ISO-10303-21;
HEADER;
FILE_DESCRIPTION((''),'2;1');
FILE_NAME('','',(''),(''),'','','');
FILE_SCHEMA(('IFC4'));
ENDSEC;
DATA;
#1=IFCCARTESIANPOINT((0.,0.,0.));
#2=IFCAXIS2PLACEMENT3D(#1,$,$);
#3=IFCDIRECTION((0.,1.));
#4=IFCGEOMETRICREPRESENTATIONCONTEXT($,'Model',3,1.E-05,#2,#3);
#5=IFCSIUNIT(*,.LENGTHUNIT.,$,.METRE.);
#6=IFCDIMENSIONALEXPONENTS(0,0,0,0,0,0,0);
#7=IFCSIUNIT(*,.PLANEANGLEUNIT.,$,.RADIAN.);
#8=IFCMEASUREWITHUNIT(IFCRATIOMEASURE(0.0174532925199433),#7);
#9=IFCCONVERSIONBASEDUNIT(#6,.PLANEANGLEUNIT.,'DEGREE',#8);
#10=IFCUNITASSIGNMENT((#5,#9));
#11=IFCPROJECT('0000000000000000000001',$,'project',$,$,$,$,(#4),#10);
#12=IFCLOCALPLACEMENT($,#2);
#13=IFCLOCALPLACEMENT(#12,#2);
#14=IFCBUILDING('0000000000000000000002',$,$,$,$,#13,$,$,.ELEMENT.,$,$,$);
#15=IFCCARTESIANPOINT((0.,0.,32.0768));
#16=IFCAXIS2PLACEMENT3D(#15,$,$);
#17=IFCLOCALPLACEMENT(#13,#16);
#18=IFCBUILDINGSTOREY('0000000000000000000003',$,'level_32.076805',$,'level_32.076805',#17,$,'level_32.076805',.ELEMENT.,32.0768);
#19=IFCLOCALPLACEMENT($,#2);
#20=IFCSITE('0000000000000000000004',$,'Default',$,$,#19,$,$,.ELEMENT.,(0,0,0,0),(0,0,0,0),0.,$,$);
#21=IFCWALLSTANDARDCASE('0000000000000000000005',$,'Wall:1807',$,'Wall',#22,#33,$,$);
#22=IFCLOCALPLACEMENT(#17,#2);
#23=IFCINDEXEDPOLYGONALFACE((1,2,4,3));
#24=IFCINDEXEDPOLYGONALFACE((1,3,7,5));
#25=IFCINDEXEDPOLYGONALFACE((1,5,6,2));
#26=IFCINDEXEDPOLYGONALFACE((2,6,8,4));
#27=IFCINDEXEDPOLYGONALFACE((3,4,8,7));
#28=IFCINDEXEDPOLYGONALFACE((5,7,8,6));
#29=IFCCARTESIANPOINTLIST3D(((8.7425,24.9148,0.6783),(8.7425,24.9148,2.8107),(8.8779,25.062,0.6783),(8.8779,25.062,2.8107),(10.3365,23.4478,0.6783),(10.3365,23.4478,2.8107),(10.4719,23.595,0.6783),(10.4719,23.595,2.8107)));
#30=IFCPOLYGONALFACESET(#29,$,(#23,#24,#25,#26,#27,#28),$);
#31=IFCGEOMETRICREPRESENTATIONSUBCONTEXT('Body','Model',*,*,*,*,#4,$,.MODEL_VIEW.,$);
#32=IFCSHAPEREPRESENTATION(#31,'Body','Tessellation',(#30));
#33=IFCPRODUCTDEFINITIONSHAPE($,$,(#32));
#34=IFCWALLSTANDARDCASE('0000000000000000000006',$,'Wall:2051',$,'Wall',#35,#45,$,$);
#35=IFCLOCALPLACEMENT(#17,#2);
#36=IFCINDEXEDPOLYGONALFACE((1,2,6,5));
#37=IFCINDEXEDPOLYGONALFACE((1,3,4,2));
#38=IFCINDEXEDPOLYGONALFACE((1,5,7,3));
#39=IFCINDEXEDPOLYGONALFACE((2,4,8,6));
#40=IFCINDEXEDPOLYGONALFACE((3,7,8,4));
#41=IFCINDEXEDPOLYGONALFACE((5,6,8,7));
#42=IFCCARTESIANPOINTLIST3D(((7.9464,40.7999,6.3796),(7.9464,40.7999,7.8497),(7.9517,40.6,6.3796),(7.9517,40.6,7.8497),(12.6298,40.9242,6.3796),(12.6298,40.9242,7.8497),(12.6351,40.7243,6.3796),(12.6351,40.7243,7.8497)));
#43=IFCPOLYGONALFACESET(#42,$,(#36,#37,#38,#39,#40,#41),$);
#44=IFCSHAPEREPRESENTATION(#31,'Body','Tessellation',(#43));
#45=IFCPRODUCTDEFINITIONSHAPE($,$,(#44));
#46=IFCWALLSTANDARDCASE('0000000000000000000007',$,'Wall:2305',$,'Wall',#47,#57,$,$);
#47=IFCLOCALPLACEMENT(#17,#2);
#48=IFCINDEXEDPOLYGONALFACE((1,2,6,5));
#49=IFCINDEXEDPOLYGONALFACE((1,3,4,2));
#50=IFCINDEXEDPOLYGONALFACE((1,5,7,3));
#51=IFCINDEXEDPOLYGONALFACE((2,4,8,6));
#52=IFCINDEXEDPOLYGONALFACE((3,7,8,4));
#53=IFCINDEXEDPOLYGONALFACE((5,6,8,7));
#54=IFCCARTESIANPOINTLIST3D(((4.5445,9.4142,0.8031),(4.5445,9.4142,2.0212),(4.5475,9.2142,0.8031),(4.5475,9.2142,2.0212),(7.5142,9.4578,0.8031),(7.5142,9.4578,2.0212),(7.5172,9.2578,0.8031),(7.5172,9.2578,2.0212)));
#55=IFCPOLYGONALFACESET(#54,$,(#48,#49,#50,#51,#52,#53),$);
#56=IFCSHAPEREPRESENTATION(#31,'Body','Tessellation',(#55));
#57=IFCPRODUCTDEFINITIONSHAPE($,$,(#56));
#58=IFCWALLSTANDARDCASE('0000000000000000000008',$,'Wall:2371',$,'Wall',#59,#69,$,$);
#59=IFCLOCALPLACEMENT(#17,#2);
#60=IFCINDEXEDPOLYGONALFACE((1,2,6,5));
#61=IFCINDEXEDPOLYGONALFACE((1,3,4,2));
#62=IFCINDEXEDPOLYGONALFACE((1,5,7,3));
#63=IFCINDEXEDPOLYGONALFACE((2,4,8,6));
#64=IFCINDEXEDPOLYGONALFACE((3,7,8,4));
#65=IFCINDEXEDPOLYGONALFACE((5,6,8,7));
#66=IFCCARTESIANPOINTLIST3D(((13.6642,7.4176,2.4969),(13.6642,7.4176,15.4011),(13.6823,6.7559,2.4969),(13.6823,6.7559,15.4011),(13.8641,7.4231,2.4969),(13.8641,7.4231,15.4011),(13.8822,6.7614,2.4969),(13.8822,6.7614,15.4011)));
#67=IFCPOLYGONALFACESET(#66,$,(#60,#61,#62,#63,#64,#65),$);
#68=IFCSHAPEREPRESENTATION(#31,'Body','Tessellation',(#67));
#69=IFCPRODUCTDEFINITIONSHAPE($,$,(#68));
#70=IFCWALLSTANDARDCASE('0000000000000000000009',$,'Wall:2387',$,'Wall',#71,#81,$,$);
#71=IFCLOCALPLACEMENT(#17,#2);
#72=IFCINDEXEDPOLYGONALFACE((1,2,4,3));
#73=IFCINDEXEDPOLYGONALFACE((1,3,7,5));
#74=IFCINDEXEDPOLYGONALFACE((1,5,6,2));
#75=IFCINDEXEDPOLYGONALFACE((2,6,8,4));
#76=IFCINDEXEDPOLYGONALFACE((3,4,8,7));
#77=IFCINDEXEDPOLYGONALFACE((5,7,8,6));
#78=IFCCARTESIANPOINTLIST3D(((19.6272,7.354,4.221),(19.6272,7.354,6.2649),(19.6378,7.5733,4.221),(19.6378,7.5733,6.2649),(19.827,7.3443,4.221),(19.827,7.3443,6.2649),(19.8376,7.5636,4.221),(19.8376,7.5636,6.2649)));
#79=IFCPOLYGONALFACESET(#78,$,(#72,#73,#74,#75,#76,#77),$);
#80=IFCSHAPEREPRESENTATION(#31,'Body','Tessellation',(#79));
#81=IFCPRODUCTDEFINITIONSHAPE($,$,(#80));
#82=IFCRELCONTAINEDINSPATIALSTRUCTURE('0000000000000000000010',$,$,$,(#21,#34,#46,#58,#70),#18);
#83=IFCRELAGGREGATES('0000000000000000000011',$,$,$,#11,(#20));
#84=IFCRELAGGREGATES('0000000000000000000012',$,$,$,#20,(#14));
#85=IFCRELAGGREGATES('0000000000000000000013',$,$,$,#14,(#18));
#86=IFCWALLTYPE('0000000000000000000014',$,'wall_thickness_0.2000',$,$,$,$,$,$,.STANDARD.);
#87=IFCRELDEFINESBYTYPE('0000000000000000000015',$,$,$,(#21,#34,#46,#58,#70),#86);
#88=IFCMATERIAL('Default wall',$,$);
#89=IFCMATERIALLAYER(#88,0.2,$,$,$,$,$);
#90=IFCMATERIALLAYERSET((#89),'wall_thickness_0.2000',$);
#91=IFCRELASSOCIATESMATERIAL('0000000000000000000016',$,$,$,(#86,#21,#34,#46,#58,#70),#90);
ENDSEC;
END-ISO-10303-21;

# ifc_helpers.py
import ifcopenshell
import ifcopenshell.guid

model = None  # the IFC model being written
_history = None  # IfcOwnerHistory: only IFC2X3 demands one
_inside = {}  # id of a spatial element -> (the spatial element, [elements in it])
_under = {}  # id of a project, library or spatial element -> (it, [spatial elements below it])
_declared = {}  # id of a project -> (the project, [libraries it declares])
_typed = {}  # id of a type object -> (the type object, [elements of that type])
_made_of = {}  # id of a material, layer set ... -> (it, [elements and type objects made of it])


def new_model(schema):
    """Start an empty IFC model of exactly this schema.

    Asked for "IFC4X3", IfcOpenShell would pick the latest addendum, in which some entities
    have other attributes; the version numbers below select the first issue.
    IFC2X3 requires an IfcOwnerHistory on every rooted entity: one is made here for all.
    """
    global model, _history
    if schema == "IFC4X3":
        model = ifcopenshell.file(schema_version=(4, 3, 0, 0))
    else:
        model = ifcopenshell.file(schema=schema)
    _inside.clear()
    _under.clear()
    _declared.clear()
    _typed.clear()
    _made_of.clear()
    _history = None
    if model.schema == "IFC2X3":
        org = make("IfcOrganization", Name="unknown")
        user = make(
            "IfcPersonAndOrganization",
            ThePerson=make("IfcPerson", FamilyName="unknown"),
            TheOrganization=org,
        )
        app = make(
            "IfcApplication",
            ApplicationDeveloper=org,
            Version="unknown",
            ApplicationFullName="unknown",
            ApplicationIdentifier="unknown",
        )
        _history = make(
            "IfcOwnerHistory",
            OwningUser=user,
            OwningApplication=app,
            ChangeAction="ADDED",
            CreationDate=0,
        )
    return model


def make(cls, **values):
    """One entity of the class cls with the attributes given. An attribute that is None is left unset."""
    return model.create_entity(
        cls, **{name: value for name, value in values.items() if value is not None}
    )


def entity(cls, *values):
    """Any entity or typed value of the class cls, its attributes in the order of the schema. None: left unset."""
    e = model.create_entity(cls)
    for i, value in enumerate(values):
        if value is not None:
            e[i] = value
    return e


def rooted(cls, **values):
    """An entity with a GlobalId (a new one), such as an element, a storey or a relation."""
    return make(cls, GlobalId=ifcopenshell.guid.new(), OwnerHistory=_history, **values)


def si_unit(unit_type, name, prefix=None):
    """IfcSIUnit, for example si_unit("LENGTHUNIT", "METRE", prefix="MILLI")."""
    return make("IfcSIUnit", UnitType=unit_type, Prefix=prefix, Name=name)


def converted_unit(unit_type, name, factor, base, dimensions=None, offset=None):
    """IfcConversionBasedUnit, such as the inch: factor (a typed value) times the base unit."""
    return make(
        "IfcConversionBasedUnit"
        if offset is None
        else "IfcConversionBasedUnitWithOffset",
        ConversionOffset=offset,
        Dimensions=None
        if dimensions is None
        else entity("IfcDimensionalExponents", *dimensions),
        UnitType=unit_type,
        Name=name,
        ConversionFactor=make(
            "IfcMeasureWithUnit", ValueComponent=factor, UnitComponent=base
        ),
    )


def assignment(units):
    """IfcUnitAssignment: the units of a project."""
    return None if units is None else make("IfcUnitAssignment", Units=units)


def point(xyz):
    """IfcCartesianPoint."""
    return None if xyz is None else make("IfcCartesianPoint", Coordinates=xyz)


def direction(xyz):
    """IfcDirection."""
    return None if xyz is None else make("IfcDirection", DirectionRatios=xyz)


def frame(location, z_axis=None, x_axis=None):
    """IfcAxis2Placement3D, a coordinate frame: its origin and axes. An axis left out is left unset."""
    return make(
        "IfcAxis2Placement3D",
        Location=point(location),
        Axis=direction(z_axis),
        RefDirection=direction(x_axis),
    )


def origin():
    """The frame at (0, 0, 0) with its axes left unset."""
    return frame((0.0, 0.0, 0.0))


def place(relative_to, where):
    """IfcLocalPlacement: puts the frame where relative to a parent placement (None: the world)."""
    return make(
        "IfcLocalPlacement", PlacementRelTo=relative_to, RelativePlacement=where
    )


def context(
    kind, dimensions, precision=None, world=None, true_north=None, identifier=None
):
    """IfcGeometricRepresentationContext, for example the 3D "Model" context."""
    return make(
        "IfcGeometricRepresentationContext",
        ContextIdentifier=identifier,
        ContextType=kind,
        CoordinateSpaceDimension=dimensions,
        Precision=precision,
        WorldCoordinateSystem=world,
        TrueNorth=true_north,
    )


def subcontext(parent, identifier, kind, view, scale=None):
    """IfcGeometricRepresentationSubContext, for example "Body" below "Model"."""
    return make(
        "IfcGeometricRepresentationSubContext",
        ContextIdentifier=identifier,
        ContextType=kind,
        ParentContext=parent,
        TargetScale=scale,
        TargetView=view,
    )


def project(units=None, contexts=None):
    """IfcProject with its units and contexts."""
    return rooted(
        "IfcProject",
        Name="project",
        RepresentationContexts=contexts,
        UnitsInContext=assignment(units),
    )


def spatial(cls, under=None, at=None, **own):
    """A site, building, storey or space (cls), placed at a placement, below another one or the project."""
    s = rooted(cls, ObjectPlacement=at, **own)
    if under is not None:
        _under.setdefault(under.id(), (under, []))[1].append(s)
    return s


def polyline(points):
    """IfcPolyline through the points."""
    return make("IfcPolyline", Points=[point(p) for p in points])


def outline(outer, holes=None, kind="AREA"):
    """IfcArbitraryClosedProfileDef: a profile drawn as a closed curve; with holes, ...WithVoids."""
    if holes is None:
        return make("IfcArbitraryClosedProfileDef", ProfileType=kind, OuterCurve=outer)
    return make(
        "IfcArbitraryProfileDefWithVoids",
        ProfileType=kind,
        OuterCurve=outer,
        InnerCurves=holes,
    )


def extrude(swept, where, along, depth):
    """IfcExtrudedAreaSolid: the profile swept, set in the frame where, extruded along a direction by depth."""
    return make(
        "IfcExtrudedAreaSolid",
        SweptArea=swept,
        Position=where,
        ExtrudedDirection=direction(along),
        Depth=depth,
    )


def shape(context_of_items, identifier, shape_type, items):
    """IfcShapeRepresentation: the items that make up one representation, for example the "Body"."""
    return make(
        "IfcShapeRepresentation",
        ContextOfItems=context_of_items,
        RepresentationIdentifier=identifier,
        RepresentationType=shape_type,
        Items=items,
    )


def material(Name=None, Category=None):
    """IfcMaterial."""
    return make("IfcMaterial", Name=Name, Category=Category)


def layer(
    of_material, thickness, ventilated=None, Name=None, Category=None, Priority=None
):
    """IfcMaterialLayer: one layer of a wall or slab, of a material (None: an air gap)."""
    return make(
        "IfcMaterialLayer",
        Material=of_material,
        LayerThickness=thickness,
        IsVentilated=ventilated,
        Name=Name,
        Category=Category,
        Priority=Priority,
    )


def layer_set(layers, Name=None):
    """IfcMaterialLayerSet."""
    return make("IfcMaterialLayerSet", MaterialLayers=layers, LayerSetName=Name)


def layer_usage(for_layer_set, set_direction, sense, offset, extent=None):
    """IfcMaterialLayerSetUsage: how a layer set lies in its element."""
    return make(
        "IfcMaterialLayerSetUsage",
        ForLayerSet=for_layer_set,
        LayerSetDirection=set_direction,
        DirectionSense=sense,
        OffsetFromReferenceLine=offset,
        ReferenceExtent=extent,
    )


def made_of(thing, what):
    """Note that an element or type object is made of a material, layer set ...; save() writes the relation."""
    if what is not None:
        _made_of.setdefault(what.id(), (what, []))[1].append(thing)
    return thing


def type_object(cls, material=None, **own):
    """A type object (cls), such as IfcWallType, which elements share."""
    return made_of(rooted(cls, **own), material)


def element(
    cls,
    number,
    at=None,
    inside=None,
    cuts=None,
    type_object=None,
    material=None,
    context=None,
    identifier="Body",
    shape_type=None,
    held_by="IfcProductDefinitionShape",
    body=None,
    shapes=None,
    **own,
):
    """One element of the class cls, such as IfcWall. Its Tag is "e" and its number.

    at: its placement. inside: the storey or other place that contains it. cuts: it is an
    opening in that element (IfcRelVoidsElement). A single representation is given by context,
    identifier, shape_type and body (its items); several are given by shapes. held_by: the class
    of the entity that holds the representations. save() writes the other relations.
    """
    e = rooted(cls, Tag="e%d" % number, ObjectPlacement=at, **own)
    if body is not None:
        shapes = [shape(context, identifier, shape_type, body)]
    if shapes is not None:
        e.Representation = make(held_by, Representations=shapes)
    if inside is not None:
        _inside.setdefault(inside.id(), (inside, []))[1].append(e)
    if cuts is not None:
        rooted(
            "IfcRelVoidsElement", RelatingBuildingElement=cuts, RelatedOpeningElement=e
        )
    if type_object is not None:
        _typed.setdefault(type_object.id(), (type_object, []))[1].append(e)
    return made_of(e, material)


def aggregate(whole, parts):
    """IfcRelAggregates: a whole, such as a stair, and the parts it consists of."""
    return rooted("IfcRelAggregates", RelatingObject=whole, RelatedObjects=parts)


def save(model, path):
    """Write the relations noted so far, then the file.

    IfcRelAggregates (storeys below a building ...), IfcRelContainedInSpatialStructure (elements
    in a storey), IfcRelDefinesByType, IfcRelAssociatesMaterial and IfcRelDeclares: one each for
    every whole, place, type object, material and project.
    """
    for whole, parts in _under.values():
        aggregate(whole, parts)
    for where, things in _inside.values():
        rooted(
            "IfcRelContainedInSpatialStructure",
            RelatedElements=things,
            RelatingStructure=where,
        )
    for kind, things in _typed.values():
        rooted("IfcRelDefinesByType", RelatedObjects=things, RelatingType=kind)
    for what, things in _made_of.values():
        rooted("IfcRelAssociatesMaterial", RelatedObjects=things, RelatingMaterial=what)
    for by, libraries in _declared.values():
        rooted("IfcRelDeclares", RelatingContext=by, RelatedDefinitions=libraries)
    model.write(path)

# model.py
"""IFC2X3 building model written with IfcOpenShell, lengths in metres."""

from ifc_helpers import new_model, entity, si_unit, converted_unit, direction, frame, origin, place, context, subcontext, project, spatial, polyline, outline, extrude, material, layer, layer_set, layer_usage, type_object, element, save


model = new_model("IFC2X3")

# Units and contexts
model_context = context("Model", 3, precision=1e-05, world=origin(), true_north=direction((0.0, 1.0)))
body_context = subcontext(model_context, "Body", "Model", "MODEL_VIEW")
ifc_project = project(units=[si_unit("LENGTHUNIT", "METRE"), converted_unit("PLANEANGLEUNIT", "DEGREE", entity("IfcRatioMeasure", 0.0174532925199433), si_unit("PLANEANGLEUNIT", "RADIAN"), dimensions=[0, 0, 0, 0, 0, 0, 0])], contexts=[model_context])

# Site, building, storey
site_placement = place(None, origin())
site = spatial("IfcSite", under=ifc_project, at=site_placement, Name="Default", CompositionType="ELEMENT", RefLatitude=(0, 0, 0, 0), RefLongitude=(0, 0, 0, 0), RefElevation=0.0)
placement_1 = place(None, origin())
building_placement = place(placement_1, origin())
building = spatial("IfcBuilding", under=site, at=building_placement, CompositionType="ELEMENT")
storey_placement = place(building_placement, frame((0.0, 0.0, 32.0768)))
storey = spatial("IfcBuildingStorey", under=building, at=storey_placement, Name="level_32.076805", ObjectType="level_32.076805", LongName="level_32.076805", CompositionType="ELEMENT", Elevation=32.0768)

# Walls
ifc_material = material(Name="Default wall")
ifc_layer = layer(ifc_material, 0.2)
ifc_layer_set = layer_set([ifc_layer], Name="wall_thickness_0.2000")
ifc_layer_usage = layer_usage(ifc_layer_set, "AXIS2", "POSITIVE", -0.1)
wall_type = type_object("IfcWallType", Name="wall_thickness_0.2000", PredefinedType="STANDARD", material=ifc_layer_set)
placement_2 = place(building_placement, frame((0.0, 0.0, 32.7551)))
wall_1_placement = place(placement_2, frame((10.4042, 23.5214, 0.0), z_axis=(0.0, 0.0, 1.0), x_axis=(-0.735808, 0.67719, 0.0)))
element("IfcWallStandardCase", 1, at=wall_1_placement, inside=storey, type_object=wall_type, material=ifc_layer_usage, Name="Wall:1807", ObjectType="Wall", context=body_context, shape_type="SweptSolid", body=[
    extrude(outline(polyline([(2.1663, -0.1), (2.1663, 0.1), (0.0, 0.1), (0.0, -0.1), (2.1663, -0.1)])), origin(), (0.0, 0.0, 1.0), 2.1324),
])
placement_3 = place(building_placement, frame((0.0, 0.0, 38.4564)))
wall_2_placement = place(placement_3, frame((7.9491, 40.6999, 0.0), z_axis=(0.0, 0.0, 1.0), x_axis=(0.999648, 0.026533, 0.0)))
element("IfcWallStandardCase", 2, at=wall_2_placement, inside=storey, type_object=wall_type, material=ifc_layer_usage, Name="Wall:2051", ObjectType="Wall", context=body_context, shape_type="SweptSolid", body=[
    extrude(outline(polyline([(4.685, -0.1), (4.685, 0.1), (0.0, 0.1), (0.0, -0.1), (4.685, -0.1)])), origin(), (0.0, 0.0, 1.0), 1.4701),
])
placement_4 = place(building_placement, frame((0.0, 0.0, 32.8799)))
wall_3_placement = place(placement_4, frame((4.546, 9.3142, 0.0), z_axis=(0.0, 0.0, 1.0), x_axis=(0.999892, 0.014681, 0.0)))
element("IfcWallStandardCase", 3, at=wall_3_placement, inside=storey, type_object=wall_type, material=ifc_layer_usage, Name="Wall:2305", ObjectType="Wall", context=body_context, shape_type="SweptSolid", body=[
    extrude(outline(polyline([(2.97, -0.1), (2.97, 0.1), (0.0, 0.1), (0.0, -0.1), (2.97, -0.1)])), origin(), (0.0, 0.0, 1.0), 1.2181),
])
placement_5 = place(building_placement, frame((0.0, 0.0, 34.5737)))
wall_4_placement = place(placement_5, frame((13.7642, 7.4204, 0.0), z_axis=(0.0, 0.0, 1.0), x_axis=(0.02733, -0.999626, 0.0)))
element("IfcWallStandardCase", 4, at=wall_4_placement, inside=storey, type_object=wall_type, material=ifc_layer_usage, Name="Wall:2371", ObjectType="Wall", context=body_context, shape_type="SweptSolid", body=[
    extrude(outline(polyline([(0.6619, -0.1), (0.6619, 0.1), (0.0, 0.1), (0.0, -0.1), (0.6619, -0.1)])), origin(), (0.0, 0.0, 1.0), 12.9042),
])
placement_6 = place(building_placement, frame((0.0, 0.0, 36.2978)))
wall_5_placement = place(placement_6, frame((19.7271, 7.3492, 0.0), z_axis=(0.0, 0.0, 1.0), x_axis=(0.048498, 0.998823, 0.0)))
element("IfcWallStandardCase", 5, at=wall_5_placement, inside=storey, type_object=wall_type, material=ifc_layer_usage, Name="Wall:2387", ObjectType="Wall", context=body_context, shape_type="SweptSolid", body=[
    extrude(outline(polyline([(0.2195, -0.1), (0.2195, 0.1), (0.0, 0.1), (0.0, -0.1), (0.2195, -0.1)])), origin(), (0.0, 0.0, 1.0), 2.0439),
])

save(model, "model.ifc")
